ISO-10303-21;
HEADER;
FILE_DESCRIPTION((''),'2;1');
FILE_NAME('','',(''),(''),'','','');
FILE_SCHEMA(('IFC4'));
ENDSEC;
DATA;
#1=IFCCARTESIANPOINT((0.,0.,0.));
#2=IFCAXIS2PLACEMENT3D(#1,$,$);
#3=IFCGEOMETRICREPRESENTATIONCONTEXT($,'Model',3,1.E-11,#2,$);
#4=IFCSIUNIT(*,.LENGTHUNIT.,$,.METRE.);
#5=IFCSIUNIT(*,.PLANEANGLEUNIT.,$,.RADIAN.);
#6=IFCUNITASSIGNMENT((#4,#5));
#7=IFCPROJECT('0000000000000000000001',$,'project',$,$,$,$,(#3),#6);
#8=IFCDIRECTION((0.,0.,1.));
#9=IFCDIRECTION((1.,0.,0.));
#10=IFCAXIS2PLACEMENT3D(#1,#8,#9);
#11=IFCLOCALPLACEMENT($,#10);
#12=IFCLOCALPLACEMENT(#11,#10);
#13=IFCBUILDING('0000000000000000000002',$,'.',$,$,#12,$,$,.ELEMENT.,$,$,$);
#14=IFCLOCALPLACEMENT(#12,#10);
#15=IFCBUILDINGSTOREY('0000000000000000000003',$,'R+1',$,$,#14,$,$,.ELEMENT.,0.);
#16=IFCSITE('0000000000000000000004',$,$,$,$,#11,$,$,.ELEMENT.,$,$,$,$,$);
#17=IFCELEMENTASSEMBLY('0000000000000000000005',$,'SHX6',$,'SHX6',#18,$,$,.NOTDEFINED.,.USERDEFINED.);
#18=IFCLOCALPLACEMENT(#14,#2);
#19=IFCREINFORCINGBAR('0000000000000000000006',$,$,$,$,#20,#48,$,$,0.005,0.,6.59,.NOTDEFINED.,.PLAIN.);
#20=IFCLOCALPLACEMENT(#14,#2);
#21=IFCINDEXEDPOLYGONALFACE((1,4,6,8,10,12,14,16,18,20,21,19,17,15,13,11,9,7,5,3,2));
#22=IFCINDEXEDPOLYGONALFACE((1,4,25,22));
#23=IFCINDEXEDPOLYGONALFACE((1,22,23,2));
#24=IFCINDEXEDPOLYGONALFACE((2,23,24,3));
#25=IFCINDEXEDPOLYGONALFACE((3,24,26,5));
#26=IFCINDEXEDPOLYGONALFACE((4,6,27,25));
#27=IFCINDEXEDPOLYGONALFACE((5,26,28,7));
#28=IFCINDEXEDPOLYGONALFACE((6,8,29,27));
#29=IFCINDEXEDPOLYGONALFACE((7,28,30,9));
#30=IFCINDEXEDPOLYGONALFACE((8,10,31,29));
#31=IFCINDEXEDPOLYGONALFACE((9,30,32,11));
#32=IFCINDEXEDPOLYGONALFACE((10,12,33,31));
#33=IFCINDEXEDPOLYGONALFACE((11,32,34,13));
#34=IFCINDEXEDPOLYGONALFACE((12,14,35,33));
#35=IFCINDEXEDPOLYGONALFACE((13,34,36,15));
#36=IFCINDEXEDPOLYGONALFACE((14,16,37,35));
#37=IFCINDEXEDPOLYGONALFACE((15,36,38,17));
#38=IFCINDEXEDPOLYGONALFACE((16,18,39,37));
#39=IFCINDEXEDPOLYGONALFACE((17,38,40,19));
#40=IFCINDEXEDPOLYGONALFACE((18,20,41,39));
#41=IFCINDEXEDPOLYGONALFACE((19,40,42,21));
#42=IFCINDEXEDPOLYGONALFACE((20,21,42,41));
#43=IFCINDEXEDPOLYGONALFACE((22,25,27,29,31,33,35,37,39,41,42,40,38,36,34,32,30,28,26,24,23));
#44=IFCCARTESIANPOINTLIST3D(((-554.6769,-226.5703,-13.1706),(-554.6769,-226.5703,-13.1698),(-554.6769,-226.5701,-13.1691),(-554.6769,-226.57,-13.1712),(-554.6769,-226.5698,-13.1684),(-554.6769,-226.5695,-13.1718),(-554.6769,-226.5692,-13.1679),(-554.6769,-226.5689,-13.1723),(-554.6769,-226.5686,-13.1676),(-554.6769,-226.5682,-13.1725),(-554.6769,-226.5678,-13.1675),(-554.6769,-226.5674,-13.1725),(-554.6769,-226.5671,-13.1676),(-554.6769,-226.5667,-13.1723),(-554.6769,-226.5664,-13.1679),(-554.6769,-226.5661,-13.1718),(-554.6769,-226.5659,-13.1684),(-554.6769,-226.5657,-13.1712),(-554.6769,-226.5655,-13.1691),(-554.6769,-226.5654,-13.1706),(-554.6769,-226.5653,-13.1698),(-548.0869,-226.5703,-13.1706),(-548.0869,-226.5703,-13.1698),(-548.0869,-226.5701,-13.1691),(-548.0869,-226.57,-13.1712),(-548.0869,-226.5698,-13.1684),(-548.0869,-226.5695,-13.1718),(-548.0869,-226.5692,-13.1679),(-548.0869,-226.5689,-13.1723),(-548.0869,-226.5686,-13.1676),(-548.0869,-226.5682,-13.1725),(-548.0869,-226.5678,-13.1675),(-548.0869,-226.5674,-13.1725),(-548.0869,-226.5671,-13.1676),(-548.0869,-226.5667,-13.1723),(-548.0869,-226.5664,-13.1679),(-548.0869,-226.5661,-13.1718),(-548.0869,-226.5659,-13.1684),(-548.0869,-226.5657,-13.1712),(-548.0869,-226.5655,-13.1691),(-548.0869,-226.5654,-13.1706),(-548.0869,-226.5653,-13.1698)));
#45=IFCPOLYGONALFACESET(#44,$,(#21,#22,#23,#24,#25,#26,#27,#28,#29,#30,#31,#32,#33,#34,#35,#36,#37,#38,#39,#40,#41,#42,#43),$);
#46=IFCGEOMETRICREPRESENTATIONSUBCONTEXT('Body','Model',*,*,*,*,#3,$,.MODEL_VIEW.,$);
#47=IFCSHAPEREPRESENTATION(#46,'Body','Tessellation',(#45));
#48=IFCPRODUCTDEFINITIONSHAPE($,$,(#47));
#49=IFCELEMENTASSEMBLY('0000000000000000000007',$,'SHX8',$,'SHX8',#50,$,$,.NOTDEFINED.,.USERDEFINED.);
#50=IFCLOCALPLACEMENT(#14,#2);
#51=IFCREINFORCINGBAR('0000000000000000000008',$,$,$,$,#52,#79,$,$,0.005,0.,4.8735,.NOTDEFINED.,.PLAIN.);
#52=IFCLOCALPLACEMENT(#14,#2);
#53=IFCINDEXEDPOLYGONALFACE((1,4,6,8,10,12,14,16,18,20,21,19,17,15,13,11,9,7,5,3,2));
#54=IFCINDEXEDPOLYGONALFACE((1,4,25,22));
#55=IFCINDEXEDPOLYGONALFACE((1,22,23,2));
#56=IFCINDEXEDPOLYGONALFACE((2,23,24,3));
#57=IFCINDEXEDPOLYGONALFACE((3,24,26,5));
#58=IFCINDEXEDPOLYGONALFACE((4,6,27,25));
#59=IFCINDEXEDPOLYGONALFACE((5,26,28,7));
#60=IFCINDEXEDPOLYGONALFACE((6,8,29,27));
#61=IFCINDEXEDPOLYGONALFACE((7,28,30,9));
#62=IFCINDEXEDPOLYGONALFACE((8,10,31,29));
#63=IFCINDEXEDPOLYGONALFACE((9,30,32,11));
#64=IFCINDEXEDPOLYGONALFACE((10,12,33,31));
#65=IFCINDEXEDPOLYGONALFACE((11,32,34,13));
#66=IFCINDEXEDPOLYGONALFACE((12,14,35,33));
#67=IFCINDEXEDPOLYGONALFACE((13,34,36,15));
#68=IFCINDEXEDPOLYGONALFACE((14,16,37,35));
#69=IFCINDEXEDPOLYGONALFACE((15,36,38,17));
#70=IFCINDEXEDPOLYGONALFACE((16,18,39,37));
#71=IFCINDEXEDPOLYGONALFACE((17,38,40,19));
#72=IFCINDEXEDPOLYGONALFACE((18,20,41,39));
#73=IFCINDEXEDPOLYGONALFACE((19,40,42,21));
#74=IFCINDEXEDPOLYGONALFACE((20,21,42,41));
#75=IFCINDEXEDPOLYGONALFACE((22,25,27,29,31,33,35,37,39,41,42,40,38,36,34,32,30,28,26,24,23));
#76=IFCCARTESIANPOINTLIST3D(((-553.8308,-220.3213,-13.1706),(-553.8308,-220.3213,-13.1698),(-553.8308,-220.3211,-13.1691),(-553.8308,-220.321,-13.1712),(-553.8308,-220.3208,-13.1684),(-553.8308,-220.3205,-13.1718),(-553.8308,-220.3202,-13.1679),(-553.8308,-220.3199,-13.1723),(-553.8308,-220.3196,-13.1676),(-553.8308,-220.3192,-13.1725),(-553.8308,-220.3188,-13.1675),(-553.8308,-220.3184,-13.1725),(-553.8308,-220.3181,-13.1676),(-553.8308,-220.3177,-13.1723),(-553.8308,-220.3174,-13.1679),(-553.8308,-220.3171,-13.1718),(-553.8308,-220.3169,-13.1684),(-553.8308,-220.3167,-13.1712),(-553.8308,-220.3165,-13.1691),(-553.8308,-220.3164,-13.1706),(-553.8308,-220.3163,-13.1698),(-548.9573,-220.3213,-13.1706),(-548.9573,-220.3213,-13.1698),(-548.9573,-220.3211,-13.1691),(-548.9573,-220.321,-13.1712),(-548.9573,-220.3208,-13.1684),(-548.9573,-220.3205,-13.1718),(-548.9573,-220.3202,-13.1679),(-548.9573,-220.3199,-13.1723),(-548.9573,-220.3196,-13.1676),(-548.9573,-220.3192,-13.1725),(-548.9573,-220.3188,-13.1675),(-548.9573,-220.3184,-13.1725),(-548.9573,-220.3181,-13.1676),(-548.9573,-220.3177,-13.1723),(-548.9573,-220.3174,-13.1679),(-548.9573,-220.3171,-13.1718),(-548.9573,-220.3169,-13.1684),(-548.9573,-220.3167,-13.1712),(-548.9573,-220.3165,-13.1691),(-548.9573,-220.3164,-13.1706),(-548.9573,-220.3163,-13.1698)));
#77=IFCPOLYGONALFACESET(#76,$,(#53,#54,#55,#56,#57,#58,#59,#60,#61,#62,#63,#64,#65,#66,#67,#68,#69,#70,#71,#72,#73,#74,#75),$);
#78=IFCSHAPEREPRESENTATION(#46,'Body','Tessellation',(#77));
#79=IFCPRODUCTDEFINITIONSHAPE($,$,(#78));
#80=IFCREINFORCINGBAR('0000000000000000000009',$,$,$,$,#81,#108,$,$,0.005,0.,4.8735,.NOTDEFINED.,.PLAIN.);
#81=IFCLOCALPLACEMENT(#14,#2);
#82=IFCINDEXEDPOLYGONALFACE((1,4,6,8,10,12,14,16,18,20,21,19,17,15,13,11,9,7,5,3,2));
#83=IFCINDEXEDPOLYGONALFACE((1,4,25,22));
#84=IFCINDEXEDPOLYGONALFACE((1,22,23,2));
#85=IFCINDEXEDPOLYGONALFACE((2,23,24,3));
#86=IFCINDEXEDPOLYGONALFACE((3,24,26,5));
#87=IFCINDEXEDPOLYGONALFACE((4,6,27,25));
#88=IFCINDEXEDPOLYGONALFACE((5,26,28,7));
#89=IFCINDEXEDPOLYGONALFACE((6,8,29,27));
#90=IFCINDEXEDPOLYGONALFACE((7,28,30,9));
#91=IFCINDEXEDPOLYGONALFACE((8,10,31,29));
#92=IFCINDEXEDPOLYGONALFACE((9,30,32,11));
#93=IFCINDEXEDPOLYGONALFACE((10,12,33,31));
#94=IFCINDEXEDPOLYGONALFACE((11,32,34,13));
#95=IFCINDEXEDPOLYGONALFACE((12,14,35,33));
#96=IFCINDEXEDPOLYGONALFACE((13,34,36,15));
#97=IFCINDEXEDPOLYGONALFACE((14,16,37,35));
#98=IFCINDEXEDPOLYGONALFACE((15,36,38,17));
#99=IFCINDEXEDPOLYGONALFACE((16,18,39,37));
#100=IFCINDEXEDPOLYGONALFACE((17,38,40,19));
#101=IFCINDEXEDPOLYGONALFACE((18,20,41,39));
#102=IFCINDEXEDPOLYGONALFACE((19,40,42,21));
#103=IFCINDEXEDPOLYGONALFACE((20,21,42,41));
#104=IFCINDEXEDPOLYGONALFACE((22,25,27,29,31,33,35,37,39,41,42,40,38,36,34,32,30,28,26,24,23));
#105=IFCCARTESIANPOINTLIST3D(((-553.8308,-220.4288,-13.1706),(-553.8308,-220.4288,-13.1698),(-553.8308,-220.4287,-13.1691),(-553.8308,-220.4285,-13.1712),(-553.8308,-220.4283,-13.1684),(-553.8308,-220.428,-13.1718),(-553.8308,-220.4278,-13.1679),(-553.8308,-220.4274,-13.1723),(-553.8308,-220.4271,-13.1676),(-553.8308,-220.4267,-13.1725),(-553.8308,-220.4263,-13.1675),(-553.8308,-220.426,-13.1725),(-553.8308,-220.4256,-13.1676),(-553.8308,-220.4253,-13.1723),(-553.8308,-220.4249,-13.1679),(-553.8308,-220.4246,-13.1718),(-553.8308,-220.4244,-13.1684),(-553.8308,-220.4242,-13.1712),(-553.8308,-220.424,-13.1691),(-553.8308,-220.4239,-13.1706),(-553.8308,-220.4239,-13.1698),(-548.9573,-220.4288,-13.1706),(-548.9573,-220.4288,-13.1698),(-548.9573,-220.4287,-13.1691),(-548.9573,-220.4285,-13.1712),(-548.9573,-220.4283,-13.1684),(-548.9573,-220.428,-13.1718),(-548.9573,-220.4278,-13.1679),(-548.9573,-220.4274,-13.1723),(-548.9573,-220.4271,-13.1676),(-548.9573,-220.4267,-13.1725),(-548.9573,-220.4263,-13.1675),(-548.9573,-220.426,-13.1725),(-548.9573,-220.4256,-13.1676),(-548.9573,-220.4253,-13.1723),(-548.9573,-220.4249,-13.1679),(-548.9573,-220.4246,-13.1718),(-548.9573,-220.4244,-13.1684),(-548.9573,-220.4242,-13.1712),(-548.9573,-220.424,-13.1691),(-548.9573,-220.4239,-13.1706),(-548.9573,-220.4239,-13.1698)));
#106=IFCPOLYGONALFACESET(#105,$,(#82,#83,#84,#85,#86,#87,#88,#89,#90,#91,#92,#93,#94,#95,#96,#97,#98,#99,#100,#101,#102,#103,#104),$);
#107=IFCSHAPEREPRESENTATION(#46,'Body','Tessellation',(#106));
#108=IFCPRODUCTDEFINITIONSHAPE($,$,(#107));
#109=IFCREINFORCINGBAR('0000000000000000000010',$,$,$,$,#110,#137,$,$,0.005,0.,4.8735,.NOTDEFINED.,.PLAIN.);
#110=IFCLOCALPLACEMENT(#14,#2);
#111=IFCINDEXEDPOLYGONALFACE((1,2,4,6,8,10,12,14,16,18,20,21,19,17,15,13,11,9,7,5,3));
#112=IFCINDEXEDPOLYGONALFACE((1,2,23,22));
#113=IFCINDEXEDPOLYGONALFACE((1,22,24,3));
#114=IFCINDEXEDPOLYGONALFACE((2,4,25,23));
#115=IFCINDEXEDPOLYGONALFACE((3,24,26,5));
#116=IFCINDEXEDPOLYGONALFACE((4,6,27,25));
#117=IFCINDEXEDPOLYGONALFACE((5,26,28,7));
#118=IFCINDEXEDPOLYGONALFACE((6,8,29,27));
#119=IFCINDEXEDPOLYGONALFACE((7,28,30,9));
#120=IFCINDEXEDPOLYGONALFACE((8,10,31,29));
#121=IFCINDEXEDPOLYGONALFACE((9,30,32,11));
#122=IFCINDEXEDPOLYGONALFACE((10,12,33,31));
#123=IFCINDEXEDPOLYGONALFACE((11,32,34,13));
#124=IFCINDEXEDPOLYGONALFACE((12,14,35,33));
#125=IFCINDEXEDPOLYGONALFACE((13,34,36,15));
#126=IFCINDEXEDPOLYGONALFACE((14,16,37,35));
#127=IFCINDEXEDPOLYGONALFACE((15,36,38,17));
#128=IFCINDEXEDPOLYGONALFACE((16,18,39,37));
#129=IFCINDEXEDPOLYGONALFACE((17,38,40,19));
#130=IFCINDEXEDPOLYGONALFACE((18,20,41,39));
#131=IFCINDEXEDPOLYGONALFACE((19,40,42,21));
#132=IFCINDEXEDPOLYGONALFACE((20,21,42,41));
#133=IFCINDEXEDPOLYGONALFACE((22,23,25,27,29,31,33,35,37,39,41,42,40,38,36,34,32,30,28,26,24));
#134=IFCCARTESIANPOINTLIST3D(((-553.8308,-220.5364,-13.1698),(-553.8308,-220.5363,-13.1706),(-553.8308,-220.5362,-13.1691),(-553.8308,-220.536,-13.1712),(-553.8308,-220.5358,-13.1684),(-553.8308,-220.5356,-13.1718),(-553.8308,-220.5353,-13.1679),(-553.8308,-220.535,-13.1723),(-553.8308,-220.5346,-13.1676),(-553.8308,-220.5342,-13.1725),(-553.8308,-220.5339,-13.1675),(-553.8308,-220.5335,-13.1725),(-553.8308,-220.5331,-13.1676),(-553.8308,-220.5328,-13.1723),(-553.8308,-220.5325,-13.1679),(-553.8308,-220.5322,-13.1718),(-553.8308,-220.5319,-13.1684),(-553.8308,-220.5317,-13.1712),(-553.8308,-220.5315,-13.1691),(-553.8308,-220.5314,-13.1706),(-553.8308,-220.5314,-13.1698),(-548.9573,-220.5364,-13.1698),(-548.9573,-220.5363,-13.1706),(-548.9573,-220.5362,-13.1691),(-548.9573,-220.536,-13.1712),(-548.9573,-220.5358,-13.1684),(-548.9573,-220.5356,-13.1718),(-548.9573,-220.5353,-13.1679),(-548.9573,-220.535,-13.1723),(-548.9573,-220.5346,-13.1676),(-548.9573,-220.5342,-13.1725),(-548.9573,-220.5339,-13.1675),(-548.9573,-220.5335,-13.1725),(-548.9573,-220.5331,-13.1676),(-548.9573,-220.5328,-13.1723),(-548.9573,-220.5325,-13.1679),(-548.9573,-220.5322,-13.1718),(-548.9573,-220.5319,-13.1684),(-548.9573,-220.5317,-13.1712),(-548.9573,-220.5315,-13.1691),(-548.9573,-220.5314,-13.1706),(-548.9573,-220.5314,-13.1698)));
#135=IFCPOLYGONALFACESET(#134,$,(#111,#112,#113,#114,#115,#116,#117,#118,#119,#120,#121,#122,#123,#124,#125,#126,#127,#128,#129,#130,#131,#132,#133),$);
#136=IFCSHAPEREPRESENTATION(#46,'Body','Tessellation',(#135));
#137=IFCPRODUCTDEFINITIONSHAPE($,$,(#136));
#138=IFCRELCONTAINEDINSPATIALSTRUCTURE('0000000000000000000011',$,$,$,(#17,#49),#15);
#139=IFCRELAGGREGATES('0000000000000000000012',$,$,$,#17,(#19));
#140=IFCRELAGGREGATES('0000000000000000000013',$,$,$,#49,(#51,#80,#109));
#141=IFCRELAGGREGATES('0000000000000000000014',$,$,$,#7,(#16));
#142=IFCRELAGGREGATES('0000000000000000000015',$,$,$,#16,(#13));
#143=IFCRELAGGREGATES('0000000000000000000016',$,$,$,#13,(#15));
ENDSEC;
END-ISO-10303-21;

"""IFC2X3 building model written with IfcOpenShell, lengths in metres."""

from ifc_helpers import new_model, entity, si_unit, origin, origin_with_axes, place, context, subcontext, project, spatial, shape, element, aggregate, save


model = new_model("IFC2X3")

# Units and contexts
model_context = context("Model", 3, precision=1e-11, world=origin())
body_context = subcontext(model_context, "Body", "Model", "MODEL_VIEW")
ifc_project = project(units=[si_unit("LENGTHUNIT", "METRE"), si_unit("PLANEANGLEUNIT", "RADIAN")], contexts=[model_context])

# Site, building, storey
site_placement = place(None, origin_with_axes())
site = spatial("IfcSite", under=ifc_project, at=site_placement, CompositionType="ELEMENT")
building_placement = place(site_placement, origin_with_axes())
building = spatial("IfcBuilding", under=site, at=building_placement, Name=".", CompositionType="ELEMENT")
storey_placement = place(building_placement, origin_with_axes())
storey = spatial("IfcBuildingStorey", under=building, at=storey_placement, Name="R+1", CompositionType="ELEMENT", Elevation=0.0)

# Element assemblies, reinforcing bars
assembly_1_placement = place(storey_placement, origin_with_axes())
assembly_1 = element("IfcElementAssembly", 1, at=assembly_1_placement, inside=storey, Name="SHX6", ObjectType="SHX6", AssemblyPlace="NOTDEFINED", PredefinedType="USERDEFINED")
reinforcing_bar_1_placement = place(assembly_1_placement, origin_with_axes())
reinforcing_bar_1 = element("IfcReinforcingBar", 2, at=reinforcing_bar_1_placement, BarLength=6.59, BarRole="NOTDEFINED", BarSurface="PLAIN", CrossSectionArea=0.0, NominalDiameter=0.005, shapes=[
    shape(body_context, "Body", "AdvancedSweptSolid", [entity("IfcSweptDiskSolid", entity("IfcPolyline", [entity("IfcCartesianPoint", [548.0869, 226.5678, 13.17]), entity("IfcCartesianPoint", [554.6769, 226.5678, 13.17])]), 0.0025, None, 0.0, 6.59)]),
    shape(body_context, "Body", "AdvancedSweptSolid", [entity("IfcSweptDiskSolid", entity("IfcPolyline", [entity("IfcCartesianPoint", [548.0869, 226.5678, 13.17]), entity("IfcCartesianPoint", [554.6769, 226.5678, 13.17])]), 0.0025, None, 0.0, 6.59)]),
])
aggregate(assembly_1, [reinforcing_bar_1])
assembly_2_placement = place(storey_placement, origin_with_axes())
assembly_2 = element("IfcElementAssembly", 3, at=assembly_2_placement, inside=storey, Name="SHX8", ObjectType="SHX8", AssemblyPlace="NOTDEFINED", PredefinedType="USERDEFINED")
reinforcing_bar_2_placement = place(assembly_2_placement, origin_with_axes())
reinforcing_bar_2 = element("IfcReinforcingBar", 4, at=reinforcing_bar_2_placement, BarLength=4.8735, BarRole="NOTDEFINED", BarSurface="PLAIN", CrossSectionArea=0.0, NominalDiameter=0.005, shapes=[
    shape(body_context, "Body", "AdvancedSweptSolid", [entity("IfcSweptDiskSolid", entity("IfcPolyline", [entity("IfcCartesianPoint", [548.9573, 220.3188, 13.17]), entity("IfcCartesianPoint", [553.8308, 220.3188, 13.17])]), 0.0025, None, 0.0, 4.8735)]),
    shape(body_context, "Body", "AdvancedSweptSolid", [entity("IfcSweptDiskSolid", entity("IfcPolyline", [entity("IfcCartesianPoint", [548.9573, 220.3188, 13.17]), entity("IfcCartesianPoint", [553.8308, 220.3188, 13.17])]), 0.0025, None, 0.0, 4.8735)]),
])
reinforcing_bar_3_placement = place(assembly_2_placement, origin_with_axes())
reinforcing_bar_3 = element("IfcReinforcingBar", 5, at=reinforcing_bar_3_placement, BarLength=4.8735, BarRole="NOTDEFINED", BarSurface="PLAIN", CrossSectionArea=0.0, NominalDiameter=0.005, shapes=[
    shape(body_context, "Body", "AdvancedSweptSolid", [entity("IfcSweptDiskSolid", entity("IfcPolyline", [entity("IfcCartesianPoint", [548.9573, 220.4263, 13.17]), entity("IfcCartesianPoint", [553.8308, 220.4263, 13.17])]), 0.0025, None, 0.0, 4.8735)]),
    shape(body_context, "Body", "AdvancedSweptSolid", [entity("IfcSweptDiskSolid", entity("IfcPolyline", [entity("IfcCartesianPoint", [548.9573, 220.4263, 13.17]), entity("IfcCartesianPoint", [553.8308, 220.4263, 13.17])]), 0.0025, None, 0.0, 4.8735)]),
])
reinforcing_bar_4_placement = place(assembly_2_placement, origin_with_axes())
reinforcing_bar_4 = element("IfcReinforcingBar", 6, at=reinforcing_bar_4_placement, BarLength=4.8735, BarRole="NOTDEFINED", BarSurface="PLAIN", CrossSectionArea=0.0, NominalDiameter=0.005, shapes=[
    shape(body_context, "Body", "AdvancedSweptSolid", [entity("IfcSweptDiskSolid", entity("IfcPolyline", [entity("IfcCartesianPoint", [548.9573, 220.5339, 13.17]), entity("IfcCartesianPoint", [553.8308, 220.5339, 13.17])]), 0.0025, None, 0.0, 4.8735)]),
    shape(body_context, "Body", "AdvancedSweptSolid", [entity("IfcSweptDiskSolid", entity("IfcPolyline", [entity("IfcCartesianPoint", [548.9573, 220.5339, 13.17]), entity("IfcCartesianPoint", [553.8308, 220.5339, 13.17])]), 0.0025, None, 0.0, 4.8735)]),
])
aggregate(assembly_2, [reinforcing_bar_2, reinforcing_bar_3, reinforcing_bar_4])

save(model, "model.ifc")
